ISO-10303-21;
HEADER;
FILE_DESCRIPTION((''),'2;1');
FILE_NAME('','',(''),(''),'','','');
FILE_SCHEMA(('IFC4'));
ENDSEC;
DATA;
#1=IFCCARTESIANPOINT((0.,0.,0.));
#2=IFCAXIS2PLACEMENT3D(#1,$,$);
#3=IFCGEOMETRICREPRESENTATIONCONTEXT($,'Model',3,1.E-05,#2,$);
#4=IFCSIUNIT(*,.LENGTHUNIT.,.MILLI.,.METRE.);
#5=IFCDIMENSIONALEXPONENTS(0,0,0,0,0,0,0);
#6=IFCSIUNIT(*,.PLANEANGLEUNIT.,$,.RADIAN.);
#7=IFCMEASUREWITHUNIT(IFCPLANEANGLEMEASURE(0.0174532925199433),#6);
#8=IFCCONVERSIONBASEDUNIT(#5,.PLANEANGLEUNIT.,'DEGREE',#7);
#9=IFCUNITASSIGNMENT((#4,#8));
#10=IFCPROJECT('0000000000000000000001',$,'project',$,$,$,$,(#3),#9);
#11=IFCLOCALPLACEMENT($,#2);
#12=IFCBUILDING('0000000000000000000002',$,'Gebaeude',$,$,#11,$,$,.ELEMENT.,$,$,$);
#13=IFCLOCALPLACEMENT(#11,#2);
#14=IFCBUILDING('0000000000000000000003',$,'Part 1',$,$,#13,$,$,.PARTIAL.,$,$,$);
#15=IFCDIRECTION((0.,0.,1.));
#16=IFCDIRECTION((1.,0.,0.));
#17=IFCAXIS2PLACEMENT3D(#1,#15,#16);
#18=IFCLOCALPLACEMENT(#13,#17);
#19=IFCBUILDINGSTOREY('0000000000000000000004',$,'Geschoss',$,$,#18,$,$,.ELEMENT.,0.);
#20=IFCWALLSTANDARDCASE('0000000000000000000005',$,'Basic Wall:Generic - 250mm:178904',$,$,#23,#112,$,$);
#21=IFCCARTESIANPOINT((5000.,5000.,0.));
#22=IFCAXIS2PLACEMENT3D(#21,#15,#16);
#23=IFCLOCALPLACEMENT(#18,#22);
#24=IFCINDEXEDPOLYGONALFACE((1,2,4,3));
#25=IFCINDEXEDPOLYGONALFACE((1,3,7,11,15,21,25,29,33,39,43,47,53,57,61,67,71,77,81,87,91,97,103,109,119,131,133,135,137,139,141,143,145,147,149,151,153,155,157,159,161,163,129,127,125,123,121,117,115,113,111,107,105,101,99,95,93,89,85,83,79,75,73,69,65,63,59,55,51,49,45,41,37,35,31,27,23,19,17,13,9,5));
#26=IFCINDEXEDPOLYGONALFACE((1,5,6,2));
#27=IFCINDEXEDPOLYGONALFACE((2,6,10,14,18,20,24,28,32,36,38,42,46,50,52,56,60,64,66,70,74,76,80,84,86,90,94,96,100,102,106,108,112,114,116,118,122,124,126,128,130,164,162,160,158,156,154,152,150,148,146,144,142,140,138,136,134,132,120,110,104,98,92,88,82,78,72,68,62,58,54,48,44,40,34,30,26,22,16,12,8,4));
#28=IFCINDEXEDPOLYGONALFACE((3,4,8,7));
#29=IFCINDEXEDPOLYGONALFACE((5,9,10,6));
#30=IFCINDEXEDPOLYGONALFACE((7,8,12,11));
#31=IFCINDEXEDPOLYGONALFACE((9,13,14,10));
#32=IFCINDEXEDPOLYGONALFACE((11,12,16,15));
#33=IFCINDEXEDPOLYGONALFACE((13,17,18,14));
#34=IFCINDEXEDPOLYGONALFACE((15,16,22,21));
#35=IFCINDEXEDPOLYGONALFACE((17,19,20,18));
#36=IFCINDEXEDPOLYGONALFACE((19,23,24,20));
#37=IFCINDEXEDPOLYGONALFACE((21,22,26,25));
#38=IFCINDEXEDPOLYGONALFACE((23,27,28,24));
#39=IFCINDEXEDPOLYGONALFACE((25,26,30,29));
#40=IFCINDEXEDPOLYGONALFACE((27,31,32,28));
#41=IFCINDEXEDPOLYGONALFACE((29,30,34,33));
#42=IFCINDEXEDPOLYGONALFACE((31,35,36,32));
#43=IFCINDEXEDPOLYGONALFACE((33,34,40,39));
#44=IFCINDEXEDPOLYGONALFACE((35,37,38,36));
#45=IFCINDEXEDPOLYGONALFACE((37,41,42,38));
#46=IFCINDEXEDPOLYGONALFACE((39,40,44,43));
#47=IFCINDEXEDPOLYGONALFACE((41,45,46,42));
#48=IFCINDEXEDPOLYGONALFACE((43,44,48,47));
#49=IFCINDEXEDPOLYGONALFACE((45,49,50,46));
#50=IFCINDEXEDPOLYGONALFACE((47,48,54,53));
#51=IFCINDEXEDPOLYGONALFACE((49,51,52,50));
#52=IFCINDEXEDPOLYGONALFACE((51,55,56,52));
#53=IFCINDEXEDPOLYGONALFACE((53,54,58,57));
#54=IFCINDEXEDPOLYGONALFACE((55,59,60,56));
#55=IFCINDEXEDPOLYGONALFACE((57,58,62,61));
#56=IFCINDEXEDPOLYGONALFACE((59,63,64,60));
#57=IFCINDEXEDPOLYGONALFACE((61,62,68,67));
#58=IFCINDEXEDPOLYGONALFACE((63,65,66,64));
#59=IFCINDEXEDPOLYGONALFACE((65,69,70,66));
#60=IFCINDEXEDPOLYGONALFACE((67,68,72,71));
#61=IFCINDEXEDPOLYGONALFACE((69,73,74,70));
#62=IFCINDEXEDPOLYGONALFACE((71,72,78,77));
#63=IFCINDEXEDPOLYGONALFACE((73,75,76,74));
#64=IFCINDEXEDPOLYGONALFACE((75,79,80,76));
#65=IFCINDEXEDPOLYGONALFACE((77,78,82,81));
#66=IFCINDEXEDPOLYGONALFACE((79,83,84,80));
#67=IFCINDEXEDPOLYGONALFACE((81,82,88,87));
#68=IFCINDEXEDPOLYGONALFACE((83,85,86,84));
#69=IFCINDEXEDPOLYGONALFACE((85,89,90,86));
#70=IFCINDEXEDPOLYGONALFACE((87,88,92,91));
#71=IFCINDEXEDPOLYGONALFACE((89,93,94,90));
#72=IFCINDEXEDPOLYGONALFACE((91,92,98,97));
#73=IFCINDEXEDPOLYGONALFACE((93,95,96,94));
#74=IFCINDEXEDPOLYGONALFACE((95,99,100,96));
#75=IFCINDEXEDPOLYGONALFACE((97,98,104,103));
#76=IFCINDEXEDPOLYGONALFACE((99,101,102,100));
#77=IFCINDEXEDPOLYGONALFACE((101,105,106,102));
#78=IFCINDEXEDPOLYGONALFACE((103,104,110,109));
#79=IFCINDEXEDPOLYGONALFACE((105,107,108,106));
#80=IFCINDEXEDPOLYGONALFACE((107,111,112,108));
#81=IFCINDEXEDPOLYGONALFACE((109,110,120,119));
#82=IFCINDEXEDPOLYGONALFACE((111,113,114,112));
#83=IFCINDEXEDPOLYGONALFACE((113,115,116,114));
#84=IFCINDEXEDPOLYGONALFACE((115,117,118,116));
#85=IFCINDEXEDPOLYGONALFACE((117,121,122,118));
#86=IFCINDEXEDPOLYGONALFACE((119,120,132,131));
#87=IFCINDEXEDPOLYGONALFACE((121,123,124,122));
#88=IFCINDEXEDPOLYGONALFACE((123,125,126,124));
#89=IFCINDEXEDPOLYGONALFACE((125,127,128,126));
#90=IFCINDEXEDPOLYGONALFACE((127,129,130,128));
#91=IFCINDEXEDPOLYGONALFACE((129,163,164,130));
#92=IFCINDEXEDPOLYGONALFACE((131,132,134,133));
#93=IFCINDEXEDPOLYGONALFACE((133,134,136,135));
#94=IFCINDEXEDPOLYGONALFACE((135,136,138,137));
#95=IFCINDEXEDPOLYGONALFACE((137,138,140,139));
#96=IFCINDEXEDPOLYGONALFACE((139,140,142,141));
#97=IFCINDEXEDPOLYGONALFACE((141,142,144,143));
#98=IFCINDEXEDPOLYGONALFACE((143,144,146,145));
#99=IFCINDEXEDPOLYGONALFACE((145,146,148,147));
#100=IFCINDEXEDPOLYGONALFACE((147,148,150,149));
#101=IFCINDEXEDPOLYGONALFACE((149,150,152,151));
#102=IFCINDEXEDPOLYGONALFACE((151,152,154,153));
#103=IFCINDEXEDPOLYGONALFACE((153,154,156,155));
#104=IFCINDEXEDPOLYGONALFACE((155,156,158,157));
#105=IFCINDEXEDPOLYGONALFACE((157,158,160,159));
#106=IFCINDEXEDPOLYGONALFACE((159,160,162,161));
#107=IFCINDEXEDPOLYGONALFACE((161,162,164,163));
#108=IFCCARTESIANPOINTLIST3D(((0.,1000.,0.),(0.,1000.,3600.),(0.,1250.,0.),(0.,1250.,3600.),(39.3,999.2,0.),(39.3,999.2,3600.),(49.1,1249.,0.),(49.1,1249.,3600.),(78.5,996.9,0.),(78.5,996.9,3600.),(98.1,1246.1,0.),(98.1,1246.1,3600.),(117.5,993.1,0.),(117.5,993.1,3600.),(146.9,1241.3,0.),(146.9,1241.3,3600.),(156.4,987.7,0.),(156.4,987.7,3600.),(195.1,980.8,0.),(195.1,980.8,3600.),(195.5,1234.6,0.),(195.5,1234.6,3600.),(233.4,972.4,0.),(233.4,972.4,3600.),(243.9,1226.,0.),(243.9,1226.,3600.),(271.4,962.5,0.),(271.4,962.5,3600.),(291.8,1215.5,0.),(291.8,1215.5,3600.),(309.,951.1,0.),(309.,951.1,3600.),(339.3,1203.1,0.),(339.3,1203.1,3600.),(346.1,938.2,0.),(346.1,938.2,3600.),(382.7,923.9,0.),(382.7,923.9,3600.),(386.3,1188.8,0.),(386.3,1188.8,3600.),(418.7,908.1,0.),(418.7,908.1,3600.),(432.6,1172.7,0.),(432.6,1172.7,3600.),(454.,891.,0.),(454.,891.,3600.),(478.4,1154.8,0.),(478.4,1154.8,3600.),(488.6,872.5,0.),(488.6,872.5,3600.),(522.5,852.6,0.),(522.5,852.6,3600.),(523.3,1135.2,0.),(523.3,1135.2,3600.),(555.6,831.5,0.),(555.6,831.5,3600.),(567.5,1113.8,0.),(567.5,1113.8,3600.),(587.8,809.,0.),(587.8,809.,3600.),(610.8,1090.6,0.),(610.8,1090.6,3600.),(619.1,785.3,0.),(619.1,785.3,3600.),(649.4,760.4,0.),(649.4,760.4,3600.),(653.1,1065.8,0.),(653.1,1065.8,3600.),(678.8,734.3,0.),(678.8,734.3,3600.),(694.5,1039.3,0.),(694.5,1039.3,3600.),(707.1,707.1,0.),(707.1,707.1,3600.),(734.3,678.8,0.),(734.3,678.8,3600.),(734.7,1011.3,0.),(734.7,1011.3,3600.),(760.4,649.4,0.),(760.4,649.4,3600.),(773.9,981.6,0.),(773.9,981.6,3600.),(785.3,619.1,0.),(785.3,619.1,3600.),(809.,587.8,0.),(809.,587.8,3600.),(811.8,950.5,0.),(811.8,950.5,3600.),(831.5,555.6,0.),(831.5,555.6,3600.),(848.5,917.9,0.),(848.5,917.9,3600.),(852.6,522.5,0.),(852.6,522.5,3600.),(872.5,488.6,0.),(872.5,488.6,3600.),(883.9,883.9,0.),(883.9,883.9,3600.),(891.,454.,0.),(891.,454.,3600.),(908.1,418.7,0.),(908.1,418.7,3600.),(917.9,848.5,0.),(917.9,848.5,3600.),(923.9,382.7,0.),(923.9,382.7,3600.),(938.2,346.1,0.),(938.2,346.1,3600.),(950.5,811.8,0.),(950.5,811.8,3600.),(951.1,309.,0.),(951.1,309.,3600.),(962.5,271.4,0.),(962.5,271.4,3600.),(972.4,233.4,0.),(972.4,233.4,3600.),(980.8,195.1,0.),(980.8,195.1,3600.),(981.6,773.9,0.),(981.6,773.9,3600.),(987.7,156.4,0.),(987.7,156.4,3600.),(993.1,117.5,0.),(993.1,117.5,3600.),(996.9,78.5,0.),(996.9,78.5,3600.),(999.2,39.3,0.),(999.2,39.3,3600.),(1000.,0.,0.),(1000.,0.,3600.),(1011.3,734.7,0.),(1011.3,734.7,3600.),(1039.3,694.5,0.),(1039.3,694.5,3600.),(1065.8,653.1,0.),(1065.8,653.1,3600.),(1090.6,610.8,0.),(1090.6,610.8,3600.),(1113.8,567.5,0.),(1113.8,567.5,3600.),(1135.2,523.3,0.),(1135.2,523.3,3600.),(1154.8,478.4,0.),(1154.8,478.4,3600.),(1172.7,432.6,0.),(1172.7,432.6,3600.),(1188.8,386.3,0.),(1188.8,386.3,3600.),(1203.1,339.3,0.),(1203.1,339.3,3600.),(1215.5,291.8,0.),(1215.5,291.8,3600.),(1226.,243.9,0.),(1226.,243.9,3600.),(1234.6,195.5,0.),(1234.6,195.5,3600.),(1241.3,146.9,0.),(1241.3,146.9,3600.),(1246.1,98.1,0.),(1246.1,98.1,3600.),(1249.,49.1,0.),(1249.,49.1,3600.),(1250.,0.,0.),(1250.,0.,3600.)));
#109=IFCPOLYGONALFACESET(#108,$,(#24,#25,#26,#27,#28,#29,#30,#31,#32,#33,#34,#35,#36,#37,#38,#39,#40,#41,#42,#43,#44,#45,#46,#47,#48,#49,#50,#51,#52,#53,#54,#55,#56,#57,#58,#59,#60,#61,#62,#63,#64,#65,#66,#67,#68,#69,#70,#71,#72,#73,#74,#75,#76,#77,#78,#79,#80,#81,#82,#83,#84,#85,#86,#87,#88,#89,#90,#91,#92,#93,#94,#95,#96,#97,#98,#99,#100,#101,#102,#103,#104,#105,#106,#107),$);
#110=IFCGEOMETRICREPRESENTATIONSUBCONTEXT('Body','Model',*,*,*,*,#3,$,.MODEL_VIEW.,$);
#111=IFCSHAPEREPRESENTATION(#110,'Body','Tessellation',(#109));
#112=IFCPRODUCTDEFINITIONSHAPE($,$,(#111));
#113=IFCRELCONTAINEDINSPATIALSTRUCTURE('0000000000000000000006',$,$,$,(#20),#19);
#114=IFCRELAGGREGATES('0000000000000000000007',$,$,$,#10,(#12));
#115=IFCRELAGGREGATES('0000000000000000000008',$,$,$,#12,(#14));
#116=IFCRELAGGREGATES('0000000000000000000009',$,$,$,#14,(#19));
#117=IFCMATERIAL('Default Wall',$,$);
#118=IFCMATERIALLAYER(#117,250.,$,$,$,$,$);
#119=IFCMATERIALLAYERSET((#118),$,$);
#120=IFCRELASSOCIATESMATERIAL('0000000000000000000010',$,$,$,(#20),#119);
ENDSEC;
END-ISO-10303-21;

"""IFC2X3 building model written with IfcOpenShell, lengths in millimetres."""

from ifc_helpers import new_model, entity, si_unit, converted_unit, frame, origin, origin_with_axes, place, context, subcontext, project, spatial, polyline, outline, extrude, material, layer, layer_set, layer_usage, element, save


model = new_model("IFC2X3")

# Units and contexts
model_context = context("Model", 3, precision=1e-05, world=origin())
body_context = subcontext(model_context, "Body", "Model", "MODEL_VIEW")
ifc_project = project(units=[si_unit("LENGTHUNIT", "METRE", prefix="MILLI"), converted_unit("PLANEANGLEUNIT", "DEGREE", entity("IfcPlaneAngleMeasure", 0.0174532925199433), si_unit("PLANEANGLEUNIT", "RADIAN"), dimensions=[0, 0, 0, 0, 0, 0, 0])], contexts=[model_context])

# Buildings, storey
building_1_placement = place(None, origin())
building_1 = spatial("IfcBuilding", under=ifc_project, at=building_1_placement, Name="Gebaeude", CompositionType="ELEMENT")
building_2_placement = place(building_1_placement, origin())
building_2 = spatial("IfcBuilding", under=building_1, at=building_2_placement, Name="Part 1", CompositionType="PARTIAL")
storey_placement = place(building_2_placement, origin_with_axes())
storey = spatial("IfcBuildingStorey", under=building_2, at=storey_placement, Name="Geschoss", CompositionType="ELEMENT", Elevation=0.0)

# Wall
ifc_material_1 = material(Name="Default Wall")
ifc_layer_1 = layer(ifc_material_1, 250.0)
ifc_layer_set_1 = layer_set([ifc_layer_1])
ifc_layer_usage_1 = layer_usage(ifc_layer_set_1, "AXIS2", "NEGATIVE", 125.0)
wall_1_placement = place(storey_placement, frame((5000.0, 5000.0, 0.0), z_axis=(0.0, 0.0, 1.0), x_axis=(1.0, 0.0, 0.0)))
element("IfcWallStandardCase", 1, at=wall_1_placement, inside=storey, material=ifc_layer_usage_1, Name="Basic Wall:Generic - 250mm:178904", context=body_context, shape_type="SweptSolid", body=[
    extrude(outline(polyline([(0.0, 1250.0), (0.0, 1000.0), (39.3, 999.2), (78.5, 996.9), (117.5, 993.1), (156.4, 987.7), (195.1, 980.8), (233.4, 972.4), (271.4, 962.5), (309.0, 951.1), (346.1, 938.2), (382.7, 923.9), (418.7, 908.1), (454.0, 891.0), (488.6, 872.5), (522.5, 852.6), (555.6, 831.5), (587.8, 809.0), (619.1, 785.3), (649.4, 760.4), (678.8, 734.3), (707.1, 707.1), (734.3, 678.8), (760.4, 649.4), (785.3, 619.1), (809.0, 587.8), (831.5, 555.6), (852.6, 522.5), (872.5, 488.6), (891.0, 454.0), (908.1, 418.7), (923.9, 382.7), (938.2, 346.1), (951.1, 309.0), (962.5, 271.4), (972.4, 233.4), (980.8, 195.1), (987.7, 156.4), (993.1, 117.5), (996.9, 78.5), (999.2, 39.3), (1000.0, 0.0), (1250.0, 0.0), (1249.0, 49.1), (1246.1, 98.1), (1241.3, 146.9), (1234.6, 195.5), (1226.0, 243.9), (1215.5, 291.8), (1203.1, 339.3), (1188.8, 386.3), (1172.7, 432.6), (1154.8, 478.4), (1135.2, 523.3), (1113.8, 567.5), (1090.6, 610.8), (1065.8, 653.1), (1039.3, 694.5), (1011.3, 734.7), (981.6, 773.9), (950.5, 811.8), (917.9, 848.5), (883.9, 883.9), (848.5, 917.9), (811.8, 950.5), (773.9, 981.6), (734.7, 1011.3), (694.5, 1039.3), (653.1, 1065.8), (610.8, 1090.6), (567.5, 1113.8), (523.3, 1135.2), (478.4, 1154.8), (432.6, 1172.7), (386.3, 1188.8), (339.3, 1203.1), (291.8, 1215.5), (243.9, 1226.0), (195.5, 1234.6), (146.9, 1241.3), (98.1, 1246.1), (49.1, 1249.0), (0.0, 1250.0)])), origin_with_axes(), (0.0, 0.0, 1.0), 3600.0),
])

save(model, "model.ifc")
